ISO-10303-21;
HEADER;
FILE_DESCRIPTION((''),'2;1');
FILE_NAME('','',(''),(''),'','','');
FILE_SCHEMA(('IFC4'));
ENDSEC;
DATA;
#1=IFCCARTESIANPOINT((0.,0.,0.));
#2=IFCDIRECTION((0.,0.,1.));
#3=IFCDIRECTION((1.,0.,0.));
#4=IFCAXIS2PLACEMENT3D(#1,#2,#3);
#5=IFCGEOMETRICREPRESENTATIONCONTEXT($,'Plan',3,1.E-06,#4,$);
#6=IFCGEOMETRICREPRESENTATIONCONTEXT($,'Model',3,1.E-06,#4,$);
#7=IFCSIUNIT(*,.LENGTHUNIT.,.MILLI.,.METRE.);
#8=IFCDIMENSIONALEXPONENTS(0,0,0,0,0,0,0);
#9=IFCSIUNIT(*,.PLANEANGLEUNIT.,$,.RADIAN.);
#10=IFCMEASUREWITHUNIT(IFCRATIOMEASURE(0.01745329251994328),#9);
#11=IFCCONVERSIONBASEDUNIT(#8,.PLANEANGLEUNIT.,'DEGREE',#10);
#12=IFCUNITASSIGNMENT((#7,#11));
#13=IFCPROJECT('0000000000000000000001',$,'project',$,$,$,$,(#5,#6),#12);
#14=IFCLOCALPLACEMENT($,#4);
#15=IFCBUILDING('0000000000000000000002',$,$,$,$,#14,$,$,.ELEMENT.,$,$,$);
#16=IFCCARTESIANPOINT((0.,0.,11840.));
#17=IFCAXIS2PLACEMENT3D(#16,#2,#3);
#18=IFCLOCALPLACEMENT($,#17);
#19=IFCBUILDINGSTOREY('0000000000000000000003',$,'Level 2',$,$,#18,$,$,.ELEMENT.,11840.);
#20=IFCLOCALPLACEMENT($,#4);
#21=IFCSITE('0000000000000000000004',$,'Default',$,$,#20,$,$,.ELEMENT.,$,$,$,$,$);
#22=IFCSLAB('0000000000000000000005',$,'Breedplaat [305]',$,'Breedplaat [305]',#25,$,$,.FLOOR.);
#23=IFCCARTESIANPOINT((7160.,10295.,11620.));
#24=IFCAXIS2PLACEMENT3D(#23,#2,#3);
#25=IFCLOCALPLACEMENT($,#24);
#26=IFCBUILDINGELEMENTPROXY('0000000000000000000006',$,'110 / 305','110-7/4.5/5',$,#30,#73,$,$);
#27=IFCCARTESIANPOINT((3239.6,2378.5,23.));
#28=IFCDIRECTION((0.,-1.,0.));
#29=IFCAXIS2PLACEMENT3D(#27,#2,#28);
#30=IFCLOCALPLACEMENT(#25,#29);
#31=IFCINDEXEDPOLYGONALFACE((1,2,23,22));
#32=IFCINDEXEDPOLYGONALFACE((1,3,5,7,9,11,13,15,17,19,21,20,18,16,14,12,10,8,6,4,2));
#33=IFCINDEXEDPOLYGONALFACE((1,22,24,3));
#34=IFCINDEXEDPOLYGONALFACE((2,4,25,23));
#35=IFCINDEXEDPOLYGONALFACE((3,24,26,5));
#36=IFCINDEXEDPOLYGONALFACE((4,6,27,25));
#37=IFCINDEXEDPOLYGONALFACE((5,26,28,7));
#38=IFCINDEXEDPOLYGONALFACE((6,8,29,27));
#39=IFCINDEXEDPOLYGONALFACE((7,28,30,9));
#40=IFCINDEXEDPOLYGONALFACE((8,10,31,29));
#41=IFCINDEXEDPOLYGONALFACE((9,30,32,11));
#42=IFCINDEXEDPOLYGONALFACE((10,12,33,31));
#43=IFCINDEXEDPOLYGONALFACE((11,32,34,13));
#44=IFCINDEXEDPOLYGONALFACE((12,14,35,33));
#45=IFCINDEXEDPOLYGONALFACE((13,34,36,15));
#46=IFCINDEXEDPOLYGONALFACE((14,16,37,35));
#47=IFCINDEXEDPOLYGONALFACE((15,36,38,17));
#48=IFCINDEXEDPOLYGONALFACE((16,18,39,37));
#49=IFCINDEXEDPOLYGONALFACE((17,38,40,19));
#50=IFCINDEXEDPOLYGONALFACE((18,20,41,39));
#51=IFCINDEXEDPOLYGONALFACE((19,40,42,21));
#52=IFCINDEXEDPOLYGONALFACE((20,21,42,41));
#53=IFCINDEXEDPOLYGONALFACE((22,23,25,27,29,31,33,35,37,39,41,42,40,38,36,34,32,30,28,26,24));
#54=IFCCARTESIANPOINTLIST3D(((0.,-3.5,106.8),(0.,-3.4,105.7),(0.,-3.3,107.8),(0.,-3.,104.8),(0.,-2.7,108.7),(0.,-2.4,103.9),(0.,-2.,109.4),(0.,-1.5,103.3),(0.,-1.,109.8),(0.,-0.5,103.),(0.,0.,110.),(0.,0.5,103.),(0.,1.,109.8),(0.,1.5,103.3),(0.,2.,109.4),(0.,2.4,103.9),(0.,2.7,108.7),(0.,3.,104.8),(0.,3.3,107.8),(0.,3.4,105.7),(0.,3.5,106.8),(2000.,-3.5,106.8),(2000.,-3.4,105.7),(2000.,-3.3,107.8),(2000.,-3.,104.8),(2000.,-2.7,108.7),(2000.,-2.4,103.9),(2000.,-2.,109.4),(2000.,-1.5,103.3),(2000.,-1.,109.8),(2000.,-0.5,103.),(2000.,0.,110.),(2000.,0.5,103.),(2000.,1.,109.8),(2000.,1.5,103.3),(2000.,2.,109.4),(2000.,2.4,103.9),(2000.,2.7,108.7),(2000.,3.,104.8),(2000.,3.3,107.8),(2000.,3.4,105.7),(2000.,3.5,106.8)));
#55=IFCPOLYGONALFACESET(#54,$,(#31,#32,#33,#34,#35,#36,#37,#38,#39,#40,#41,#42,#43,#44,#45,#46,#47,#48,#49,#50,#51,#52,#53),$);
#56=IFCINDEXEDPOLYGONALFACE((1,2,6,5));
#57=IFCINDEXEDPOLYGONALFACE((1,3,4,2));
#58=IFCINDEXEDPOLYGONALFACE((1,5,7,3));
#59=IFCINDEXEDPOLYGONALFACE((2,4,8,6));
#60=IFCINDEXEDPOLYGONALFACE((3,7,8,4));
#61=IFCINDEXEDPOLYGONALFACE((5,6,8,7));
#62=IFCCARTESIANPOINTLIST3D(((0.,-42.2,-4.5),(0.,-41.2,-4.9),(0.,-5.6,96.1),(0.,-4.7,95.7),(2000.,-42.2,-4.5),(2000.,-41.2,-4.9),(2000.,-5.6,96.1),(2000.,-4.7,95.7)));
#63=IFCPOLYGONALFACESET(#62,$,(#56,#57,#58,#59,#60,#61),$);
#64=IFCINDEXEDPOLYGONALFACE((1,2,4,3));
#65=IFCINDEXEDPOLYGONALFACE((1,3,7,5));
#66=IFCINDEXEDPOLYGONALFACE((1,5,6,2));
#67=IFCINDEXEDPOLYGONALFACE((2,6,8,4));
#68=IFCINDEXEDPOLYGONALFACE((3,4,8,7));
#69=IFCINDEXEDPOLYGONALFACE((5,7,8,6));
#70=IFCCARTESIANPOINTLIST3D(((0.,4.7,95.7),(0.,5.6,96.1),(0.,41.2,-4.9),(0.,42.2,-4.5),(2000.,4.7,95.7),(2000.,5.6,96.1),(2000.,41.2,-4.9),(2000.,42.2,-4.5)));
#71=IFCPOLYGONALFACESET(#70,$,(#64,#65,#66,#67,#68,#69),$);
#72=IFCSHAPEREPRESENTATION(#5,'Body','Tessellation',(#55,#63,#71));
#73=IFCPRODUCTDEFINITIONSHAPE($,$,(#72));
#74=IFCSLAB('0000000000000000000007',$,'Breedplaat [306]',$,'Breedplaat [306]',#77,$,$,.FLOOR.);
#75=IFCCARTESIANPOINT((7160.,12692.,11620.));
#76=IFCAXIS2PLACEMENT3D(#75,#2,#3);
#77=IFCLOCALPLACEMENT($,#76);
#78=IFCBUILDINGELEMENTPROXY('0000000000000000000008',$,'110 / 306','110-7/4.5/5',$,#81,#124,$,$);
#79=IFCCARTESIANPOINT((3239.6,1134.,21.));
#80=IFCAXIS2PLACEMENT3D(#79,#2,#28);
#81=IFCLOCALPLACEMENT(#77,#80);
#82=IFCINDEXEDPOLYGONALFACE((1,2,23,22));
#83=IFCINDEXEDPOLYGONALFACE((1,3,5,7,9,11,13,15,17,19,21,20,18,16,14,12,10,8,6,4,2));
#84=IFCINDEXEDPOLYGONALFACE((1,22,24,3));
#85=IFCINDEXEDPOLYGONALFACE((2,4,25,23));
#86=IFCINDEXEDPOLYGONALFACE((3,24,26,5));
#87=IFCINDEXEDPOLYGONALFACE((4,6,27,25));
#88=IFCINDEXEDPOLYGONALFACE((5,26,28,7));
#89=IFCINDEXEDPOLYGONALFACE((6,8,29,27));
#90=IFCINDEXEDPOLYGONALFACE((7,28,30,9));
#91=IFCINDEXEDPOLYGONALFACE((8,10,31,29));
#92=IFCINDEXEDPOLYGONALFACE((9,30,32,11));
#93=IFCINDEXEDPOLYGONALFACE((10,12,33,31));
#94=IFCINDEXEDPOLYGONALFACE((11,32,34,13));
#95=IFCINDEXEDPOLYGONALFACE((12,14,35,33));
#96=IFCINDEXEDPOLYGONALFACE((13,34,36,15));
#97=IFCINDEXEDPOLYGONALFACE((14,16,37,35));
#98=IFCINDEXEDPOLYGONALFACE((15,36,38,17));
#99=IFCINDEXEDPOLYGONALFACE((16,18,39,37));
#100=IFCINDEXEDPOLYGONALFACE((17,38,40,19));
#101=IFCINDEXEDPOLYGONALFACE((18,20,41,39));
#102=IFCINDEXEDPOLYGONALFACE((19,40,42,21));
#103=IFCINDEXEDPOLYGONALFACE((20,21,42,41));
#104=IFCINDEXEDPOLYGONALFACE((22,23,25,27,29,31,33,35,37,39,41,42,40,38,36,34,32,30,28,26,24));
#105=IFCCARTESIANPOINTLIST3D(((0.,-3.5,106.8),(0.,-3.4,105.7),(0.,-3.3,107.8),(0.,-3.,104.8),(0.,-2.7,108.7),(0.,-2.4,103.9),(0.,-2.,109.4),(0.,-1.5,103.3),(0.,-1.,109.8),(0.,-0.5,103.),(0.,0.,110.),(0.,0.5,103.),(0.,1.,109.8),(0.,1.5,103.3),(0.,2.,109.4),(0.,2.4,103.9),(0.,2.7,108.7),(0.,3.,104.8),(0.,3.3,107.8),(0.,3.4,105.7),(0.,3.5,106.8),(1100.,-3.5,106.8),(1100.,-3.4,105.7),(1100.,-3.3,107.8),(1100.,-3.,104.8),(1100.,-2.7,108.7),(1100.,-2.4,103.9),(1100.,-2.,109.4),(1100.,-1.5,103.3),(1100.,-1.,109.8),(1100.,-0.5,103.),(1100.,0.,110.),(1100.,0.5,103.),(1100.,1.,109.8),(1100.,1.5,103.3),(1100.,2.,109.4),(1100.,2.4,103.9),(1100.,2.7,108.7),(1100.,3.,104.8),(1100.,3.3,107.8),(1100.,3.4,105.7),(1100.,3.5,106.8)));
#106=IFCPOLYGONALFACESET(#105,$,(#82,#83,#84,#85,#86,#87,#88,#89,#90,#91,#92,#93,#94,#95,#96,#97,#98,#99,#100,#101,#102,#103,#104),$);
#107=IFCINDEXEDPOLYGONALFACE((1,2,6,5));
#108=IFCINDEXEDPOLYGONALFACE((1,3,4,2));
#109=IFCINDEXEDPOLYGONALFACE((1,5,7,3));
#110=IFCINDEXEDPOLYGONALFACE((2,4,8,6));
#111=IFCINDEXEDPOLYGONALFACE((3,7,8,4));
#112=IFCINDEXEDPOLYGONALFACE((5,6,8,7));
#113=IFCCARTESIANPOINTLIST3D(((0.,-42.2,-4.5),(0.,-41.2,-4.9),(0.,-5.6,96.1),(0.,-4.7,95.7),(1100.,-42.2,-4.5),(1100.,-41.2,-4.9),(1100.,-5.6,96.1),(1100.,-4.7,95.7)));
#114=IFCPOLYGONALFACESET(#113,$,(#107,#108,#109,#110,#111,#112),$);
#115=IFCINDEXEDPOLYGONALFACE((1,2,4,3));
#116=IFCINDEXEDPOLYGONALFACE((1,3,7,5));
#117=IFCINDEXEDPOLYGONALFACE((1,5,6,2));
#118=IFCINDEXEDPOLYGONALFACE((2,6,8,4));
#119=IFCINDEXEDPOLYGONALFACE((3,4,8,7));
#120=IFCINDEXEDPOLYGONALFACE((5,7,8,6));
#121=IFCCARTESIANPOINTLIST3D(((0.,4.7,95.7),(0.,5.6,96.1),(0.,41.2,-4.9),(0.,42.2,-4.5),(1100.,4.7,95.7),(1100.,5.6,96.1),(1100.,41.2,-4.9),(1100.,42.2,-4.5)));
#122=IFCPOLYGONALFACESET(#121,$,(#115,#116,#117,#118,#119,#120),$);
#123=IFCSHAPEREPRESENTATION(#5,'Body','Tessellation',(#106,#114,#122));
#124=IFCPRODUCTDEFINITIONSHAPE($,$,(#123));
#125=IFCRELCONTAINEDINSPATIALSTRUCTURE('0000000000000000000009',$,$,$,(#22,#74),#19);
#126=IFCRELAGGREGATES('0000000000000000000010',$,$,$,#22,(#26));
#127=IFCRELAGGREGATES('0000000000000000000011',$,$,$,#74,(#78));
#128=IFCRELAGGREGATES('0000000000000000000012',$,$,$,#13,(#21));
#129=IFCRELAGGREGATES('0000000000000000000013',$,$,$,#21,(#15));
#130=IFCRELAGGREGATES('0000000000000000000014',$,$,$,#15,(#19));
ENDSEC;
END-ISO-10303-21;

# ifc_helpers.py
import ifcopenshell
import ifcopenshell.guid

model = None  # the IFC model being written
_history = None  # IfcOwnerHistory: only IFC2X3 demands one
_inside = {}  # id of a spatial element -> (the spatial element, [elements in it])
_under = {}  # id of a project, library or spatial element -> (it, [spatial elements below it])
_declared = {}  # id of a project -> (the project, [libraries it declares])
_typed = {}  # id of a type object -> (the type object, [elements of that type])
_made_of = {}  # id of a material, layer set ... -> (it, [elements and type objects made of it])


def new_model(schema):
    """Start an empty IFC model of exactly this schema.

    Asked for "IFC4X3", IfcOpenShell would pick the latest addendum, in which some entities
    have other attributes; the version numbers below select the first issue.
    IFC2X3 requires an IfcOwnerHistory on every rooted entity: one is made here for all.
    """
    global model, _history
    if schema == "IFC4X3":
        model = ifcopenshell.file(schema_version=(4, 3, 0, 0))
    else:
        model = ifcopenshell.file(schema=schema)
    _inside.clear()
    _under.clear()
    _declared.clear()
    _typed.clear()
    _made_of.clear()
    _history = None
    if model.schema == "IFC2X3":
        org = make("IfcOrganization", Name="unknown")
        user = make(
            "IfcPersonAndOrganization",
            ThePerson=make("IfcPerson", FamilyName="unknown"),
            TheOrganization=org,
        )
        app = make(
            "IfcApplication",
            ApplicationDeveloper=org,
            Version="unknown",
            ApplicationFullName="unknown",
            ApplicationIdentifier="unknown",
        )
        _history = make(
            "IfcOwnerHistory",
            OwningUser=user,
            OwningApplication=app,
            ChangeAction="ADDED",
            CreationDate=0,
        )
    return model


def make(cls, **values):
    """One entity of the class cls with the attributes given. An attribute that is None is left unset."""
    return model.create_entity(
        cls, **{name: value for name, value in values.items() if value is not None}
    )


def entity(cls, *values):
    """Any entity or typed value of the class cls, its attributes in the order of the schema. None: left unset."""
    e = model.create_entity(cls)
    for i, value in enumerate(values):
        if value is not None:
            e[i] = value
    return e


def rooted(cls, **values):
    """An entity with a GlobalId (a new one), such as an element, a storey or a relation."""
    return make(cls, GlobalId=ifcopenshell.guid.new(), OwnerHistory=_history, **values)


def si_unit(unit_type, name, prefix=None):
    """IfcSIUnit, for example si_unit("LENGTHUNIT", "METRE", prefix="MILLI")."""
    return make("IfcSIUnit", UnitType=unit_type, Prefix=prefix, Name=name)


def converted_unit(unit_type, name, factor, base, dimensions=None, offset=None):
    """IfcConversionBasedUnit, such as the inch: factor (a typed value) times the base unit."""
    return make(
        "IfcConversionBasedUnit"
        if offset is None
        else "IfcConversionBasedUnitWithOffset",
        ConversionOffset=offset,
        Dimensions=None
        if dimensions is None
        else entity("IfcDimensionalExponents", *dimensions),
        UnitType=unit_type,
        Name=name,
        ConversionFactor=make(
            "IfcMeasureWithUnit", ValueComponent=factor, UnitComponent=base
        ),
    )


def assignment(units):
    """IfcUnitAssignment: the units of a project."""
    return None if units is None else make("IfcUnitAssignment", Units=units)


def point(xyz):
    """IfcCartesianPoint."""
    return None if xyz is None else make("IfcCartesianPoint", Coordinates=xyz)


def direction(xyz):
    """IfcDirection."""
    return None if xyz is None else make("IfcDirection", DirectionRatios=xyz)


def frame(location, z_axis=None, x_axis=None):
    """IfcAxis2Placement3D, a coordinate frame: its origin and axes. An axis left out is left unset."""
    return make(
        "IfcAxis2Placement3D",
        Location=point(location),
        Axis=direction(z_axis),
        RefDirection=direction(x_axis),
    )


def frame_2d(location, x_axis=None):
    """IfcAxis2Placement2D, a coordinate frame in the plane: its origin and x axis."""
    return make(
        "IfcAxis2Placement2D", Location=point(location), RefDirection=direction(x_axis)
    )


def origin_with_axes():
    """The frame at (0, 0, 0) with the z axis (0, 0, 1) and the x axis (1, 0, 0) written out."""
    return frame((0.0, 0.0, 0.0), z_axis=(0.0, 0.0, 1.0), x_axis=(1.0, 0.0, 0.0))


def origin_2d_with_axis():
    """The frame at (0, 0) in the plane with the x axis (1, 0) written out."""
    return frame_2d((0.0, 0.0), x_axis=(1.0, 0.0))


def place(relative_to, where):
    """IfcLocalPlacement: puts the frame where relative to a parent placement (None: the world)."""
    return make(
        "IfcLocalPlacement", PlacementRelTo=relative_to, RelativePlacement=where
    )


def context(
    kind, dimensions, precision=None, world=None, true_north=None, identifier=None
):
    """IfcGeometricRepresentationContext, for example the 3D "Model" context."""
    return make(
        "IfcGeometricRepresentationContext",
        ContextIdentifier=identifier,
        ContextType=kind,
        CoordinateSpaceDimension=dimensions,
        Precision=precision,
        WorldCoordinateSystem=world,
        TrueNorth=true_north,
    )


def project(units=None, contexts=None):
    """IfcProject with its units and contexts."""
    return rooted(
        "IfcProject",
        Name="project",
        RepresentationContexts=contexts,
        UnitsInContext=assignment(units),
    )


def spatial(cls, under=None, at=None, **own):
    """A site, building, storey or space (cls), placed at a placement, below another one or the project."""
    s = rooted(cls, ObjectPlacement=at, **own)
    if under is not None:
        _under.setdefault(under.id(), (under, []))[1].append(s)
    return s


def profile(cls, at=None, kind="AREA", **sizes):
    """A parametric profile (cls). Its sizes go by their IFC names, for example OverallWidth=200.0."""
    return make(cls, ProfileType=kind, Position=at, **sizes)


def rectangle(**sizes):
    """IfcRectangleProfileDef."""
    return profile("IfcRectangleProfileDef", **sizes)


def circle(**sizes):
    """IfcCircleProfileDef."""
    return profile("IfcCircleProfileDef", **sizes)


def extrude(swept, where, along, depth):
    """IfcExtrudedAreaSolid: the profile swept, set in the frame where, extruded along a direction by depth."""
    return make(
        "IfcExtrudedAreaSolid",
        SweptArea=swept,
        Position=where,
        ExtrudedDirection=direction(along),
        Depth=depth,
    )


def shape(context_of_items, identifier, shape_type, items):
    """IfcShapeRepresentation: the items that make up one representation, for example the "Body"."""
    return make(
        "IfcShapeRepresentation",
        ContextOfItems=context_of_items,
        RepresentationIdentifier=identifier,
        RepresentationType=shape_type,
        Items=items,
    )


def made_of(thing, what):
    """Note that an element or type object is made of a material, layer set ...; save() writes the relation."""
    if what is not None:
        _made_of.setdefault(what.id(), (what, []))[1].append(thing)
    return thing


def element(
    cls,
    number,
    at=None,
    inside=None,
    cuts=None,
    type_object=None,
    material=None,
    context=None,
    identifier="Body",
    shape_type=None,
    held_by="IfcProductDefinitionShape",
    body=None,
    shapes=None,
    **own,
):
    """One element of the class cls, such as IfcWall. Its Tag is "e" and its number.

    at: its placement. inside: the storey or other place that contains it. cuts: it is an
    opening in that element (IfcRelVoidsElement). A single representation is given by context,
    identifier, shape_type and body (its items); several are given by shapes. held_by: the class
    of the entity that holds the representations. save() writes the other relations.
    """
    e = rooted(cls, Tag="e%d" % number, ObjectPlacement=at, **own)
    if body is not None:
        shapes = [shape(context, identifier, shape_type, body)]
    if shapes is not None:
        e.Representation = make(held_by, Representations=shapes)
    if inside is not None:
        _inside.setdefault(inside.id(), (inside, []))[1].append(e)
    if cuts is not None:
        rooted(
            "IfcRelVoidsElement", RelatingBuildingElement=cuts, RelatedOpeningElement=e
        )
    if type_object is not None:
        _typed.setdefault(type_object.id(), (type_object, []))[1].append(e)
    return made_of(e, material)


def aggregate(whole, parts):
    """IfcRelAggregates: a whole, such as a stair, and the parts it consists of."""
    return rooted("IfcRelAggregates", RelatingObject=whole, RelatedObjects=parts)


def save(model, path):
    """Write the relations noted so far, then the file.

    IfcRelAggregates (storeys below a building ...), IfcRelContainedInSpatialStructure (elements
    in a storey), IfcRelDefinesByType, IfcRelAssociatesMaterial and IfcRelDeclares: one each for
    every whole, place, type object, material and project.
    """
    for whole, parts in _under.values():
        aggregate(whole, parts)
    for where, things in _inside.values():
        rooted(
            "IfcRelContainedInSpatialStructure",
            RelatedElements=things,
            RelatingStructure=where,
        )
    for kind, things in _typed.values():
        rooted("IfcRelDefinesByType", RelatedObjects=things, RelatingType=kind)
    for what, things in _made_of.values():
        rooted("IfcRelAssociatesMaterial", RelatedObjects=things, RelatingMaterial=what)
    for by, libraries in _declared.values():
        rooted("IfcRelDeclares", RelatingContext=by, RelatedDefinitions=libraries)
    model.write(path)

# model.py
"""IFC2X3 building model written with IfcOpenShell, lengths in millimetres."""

from ifc_helpers import new_model, entity, si_unit, converted_unit, frame, origin_with_axes, origin_2d_with_axis, place, context, project, spatial, rectangle, circle, extrude, element, aggregate, save


model = new_model("IFC2X3")

# Units and contexts
plan_context = context("Plan", 3, precision=1e-06, world=origin_with_axes())
model_context = context("Model", 3, precision=1e-06, world=origin_with_axes())
ifc_project = project(units=[si_unit("LENGTHUNIT", "METRE", prefix="MILLI"), converted_unit("PLANEANGLEUNIT", "DEGREE", entity("IfcRatioMeasure", 0.01745329251994328), si_unit("PLANEANGLEUNIT", "RADIAN"), dimensions=[0, 0, 0, 0, 0, 0, 0])], contexts=[plan_context, model_context])

# Site, building, storey
site_placement = place(None, origin_with_axes())
site = spatial("IfcSite", under=ifc_project, at=site_placement, Name="Default", CompositionType="ELEMENT")
building_placement = place(None, origin_with_axes())
building = spatial("IfcBuilding", under=site, at=building_placement, CompositionType="ELEMENT")
storey_placement = place(None, frame((0.0, 0.0, 11840.0), z_axis=(0.0, 0.0, 1.0), x_axis=(1.0, 0.0, 0.0)))
storey = spatial("IfcBuildingStorey", under=building, at=storey_placement, Name="Level 2", CompositionType="ELEMENT", Elevation=11840.0)

# Slab, building element proxy
slab_1_placement = place(None, frame((7160.0, 10295.0, 11620.0), z_axis=(0.0, 0.0, 1.0), x_axis=(1.0, 0.0, 0.0)))
slab_1 = element("IfcSlab", 1, at=slab_1_placement, inside=storey, Name="Breedplaat [305]", ObjectType="Breedplaat [305]", PredefinedType="FLOOR")
proxy_1_placement = place(slab_1_placement, frame((3239.6, 2378.5, 23.0), z_axis=(0.0, 0.0, 1.0), x_axis=(0.0, -1.0, 0.0)))
proxy_1 = element("IfcBuildingElementProxy", 2, at=proxy_1_placement, Name="110 / 305", Description="110-7/4.5/5", context=plan_context, shape_type="SweptSolid", body=[
    extrude(circle(Radius=3.5, at=origin_2d_with_axis()), frame((0.0, 0.0, 106.5), z_axis=(1.0, 0.0, 0.0), x_axis=(0.0, 0.0, 1.0)), (0.0, 0.0, 1.0), 2000.0),
    extrude(rectangle(XDim=107.0, YDim=1.0, at=origin_2d_with_axis()), frame((0.0, -23.4, 45.6), z_axis=(1.0, 0.0, 0.0), x_axis=(0.0, 0.341743, 0.939793)), (0.0, 0.0, 1.0), 2000.0),
    extrude(rectangle(XDim=107.0, YDim=1.0, at=origin_2d_with_axis()), frame((0.0, 23.4, 45.6), z_axis=(1.0, 0.0, 0.0), x_axis=(0.0, -0.341743, 0.939793)), (0.0, 0.0, 1.0), 2000.0),
])
aggregate(slab_1, [proxy_1])

# Slab, building element proxy
slab_2_placement = place(None, frame((7160.0, 12692.0, 11620.0), z_axis=(0.0, 0.0, 1.0), x_axis=(1.0, 0.0, 0.0)))
slab_2 = element("IfcSlab", 3, at=slab_2_placement, inside=storey, Name="Breedplaat [306]", ObjectType="Breedplaat [306]", PredefinedType="FLOOR")
proxy_2_placement = place(slab_2_placement, frame((3239.6, 1134.0, 21.0), z_axis=(0.0, 0.0, 1.0), x_axis=(0.0, -1.0, 0.0)))
proxy_2 = element("IfcBuildingElementProxy", 4, at=proxy_2_placement, Name="110 / 306", Description="110-7/4.5/5", context=plan_context, shape_type="SweptSolid", body=[
    extrude(circle(Radius=3.5, at=origin_2d_with_axis()), frame((0.0, 0.0, 106.5), z_axis=(1.0, 0.0, 0.0), x_axis=(0.0, 0.0, 1.0)), (0.0, 0.0, 1.0), 1100.0),
    extrude(rectangle(XDim=107.0, YDim=1.0, at=origin_2d_with_axis()), frame((0.0, -23.4, 45.6), z_axis=(1.0, 0.0, 0.0), x_axis=(0.0, 0.341743, 0.939793)), (0.0, 0.0, 1.0), 1100.0),
    extrude(rectangle(XDim=107.0, YDim=1.0, at=origin_2d_with_axis()), frame((0.0, 23.4, 45.6), z_axis=(1.0, 0.0, 0.0), x_axis=(0.0, -0.341743, 0.939793)), (0.0, 0.0, 1.0), 1100.0),
])
aggregate(slab_2, [proxy_2])

save(model, "model.ifc")
